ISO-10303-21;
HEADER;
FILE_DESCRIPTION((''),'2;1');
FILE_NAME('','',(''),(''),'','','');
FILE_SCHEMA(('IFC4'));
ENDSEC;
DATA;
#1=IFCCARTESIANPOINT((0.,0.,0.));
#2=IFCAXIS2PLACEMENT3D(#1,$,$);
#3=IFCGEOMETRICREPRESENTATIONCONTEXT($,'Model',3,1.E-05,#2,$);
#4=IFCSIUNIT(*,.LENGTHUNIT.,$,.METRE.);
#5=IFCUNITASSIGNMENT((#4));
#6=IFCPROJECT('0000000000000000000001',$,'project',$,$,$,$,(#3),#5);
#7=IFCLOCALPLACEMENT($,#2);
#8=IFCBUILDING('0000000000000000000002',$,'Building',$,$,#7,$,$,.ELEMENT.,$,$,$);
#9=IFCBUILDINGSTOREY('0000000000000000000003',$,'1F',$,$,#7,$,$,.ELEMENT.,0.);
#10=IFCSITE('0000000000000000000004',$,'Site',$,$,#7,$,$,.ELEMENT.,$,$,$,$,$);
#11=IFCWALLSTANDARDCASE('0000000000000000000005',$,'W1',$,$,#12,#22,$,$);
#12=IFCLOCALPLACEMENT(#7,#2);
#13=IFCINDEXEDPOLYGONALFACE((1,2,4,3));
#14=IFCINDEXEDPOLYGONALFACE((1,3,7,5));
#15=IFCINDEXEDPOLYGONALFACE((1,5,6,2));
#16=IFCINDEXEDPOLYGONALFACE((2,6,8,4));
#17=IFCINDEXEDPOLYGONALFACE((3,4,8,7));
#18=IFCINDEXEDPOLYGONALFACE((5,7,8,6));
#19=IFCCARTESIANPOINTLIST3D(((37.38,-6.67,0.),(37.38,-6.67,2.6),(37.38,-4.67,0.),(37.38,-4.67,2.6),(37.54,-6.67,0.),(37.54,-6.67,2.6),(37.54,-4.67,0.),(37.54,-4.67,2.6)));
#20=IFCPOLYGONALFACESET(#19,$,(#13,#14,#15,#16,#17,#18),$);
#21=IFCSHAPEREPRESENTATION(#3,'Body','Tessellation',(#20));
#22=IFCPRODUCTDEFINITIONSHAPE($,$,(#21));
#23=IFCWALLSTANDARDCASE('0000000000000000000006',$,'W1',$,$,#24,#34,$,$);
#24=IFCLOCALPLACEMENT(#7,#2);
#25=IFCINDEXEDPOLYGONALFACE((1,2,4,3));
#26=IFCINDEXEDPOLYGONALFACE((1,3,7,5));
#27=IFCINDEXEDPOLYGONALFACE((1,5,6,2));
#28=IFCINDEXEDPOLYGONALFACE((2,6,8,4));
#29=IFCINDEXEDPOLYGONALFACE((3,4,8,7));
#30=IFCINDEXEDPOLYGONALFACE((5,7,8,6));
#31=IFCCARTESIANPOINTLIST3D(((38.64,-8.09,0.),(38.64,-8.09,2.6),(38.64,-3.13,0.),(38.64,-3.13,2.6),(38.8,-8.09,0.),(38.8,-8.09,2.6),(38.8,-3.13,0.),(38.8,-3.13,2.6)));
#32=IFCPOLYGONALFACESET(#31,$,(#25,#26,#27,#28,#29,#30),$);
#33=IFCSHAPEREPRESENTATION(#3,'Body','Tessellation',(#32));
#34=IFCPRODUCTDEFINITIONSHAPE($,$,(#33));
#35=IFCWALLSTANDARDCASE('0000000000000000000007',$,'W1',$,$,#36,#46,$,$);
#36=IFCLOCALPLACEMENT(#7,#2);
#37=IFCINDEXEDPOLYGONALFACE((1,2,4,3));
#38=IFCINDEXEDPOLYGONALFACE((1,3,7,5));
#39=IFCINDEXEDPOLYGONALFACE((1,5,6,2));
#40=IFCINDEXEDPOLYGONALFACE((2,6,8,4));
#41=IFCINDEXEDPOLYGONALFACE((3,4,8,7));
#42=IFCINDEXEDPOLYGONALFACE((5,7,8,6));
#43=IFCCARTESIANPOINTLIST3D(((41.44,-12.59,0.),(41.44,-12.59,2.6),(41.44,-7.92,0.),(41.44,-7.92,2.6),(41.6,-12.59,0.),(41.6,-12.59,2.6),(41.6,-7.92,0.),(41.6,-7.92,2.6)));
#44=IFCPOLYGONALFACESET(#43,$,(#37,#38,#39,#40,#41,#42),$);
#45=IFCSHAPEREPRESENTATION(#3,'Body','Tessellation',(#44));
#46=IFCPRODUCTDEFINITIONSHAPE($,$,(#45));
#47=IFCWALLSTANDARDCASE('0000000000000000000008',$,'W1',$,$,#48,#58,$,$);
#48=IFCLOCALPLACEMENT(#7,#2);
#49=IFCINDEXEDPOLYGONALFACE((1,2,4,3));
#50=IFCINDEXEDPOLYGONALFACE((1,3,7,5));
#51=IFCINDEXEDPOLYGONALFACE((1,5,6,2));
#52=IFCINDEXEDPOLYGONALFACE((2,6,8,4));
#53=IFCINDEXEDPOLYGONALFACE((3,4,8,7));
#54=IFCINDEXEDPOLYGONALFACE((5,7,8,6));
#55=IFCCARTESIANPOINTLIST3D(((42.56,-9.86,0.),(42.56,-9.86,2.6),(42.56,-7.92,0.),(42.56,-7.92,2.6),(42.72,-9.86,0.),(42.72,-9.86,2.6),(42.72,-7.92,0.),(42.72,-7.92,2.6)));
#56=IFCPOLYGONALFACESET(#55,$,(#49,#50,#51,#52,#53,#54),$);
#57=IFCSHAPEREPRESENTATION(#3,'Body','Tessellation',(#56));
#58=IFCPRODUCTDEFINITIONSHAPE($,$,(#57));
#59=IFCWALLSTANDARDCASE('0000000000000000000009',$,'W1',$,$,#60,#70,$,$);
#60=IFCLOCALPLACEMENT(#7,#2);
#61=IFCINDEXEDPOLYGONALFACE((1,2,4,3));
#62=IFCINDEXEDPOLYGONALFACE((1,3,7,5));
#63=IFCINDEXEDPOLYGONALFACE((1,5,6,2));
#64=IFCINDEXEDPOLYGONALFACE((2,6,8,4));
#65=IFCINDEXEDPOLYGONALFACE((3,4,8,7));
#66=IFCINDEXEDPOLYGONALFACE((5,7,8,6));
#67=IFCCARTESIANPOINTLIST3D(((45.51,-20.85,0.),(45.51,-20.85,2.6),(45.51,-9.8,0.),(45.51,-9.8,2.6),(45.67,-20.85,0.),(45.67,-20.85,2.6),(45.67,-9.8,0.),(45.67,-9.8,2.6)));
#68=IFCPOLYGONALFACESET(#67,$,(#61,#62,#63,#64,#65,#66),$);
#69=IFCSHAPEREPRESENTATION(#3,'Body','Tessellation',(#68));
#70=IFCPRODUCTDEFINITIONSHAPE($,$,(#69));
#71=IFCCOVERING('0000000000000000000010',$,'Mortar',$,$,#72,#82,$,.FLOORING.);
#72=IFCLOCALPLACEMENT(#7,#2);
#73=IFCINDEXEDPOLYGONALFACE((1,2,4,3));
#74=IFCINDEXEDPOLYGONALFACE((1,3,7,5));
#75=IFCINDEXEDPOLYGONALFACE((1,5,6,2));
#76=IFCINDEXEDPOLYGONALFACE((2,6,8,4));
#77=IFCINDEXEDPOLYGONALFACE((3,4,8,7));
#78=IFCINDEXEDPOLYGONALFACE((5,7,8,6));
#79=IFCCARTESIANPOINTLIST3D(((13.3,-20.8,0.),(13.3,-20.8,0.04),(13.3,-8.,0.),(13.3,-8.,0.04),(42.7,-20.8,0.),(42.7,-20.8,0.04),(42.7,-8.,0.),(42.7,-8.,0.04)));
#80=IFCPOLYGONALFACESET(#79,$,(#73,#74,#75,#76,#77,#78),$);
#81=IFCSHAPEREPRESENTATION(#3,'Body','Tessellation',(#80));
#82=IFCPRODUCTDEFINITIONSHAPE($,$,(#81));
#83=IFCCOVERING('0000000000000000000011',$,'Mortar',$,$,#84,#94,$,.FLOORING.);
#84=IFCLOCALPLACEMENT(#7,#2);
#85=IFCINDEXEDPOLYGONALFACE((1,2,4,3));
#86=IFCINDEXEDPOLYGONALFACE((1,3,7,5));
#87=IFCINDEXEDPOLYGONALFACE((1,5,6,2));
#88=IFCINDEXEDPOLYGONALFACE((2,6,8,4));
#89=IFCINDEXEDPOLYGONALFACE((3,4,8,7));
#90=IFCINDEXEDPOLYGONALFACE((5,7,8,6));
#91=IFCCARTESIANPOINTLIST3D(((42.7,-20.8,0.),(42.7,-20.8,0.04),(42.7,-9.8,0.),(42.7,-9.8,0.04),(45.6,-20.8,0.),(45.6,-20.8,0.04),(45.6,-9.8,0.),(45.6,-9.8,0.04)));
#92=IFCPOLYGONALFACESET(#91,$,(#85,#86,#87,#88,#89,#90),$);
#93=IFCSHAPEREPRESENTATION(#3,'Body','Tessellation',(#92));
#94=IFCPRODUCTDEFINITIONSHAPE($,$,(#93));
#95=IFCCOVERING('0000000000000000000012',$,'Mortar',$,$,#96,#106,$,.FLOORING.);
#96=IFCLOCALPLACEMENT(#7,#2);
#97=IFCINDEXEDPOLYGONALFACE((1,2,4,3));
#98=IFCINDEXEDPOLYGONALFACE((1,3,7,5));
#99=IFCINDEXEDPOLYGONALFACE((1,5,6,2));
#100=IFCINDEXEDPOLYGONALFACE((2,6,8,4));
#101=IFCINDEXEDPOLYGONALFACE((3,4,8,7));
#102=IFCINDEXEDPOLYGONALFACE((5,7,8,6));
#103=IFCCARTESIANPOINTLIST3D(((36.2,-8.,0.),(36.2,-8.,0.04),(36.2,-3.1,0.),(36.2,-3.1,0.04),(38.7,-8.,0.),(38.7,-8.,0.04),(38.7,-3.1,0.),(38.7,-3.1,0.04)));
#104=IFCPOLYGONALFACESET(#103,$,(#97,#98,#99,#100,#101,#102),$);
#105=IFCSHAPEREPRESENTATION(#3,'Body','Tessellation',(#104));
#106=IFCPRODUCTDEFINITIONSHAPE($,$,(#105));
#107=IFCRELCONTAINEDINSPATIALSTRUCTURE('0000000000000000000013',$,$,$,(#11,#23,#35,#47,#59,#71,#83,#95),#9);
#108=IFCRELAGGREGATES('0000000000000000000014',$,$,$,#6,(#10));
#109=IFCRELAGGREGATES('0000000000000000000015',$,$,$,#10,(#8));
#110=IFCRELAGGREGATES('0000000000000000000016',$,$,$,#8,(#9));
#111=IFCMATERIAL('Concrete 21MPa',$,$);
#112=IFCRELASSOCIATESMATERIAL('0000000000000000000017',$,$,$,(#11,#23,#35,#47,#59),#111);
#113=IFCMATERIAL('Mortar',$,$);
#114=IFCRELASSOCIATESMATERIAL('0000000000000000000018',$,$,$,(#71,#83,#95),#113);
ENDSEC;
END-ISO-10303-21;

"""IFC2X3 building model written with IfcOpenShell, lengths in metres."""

from ifc_helpers import new_model, si_unit, frame, origin, origin_2d, place, context, project, spatial, rectangle, extrude, material, element, save


model = new_model("IFC2X3")

# Units and contexts
model_context = context("Model", 3, precision=1e-05, world=origin())
ifc_project = project(units=[si_unit("LENGTHUNIT", "METRE")], contexts=[model_context])

# Site, building, storey
placement = place(None, origin())
site = spatial("IfcSite", under=ifc_project, at=placement, Name="Site", CompositionType="ELEMENT")
building = spatial("IfcBuilding", under=site, at=placement, Name="Building", CompositionType="ELEMENT")
storey = spatial("IfcBuildingStorey", under=building, at=placement, Name="1F", CompositionType="ELEMENT", Elevation=0.0)

# Shared definitions
ifc_material_1 = material(Name="Concrete 21MPa")

# Walls
wall_1_placement = place(None, frame((37.46, -5.67, 0.0)))
element("IfcWallStandardCase", 1, at=wall_1_placement, inside=storey, material=ifc_material_1, Name="W1", context=model_context, shape_type="SweptSolid", body=[
    extrude(rectangle(XDim=0.16, YDim=2.0, at=origin_2d()), origin(), (0.0, 0.0, 1.0), 2.6),
])
wall_2_placement = place(None, frame((38.72, -5.61, 0.0)))
element("IfcWallStandardCase", 2, at=wall_2_placement, inside=storey, material=ifc_material_1, Name="W1", context=model_context, shape_type="SweptSolid", body=[
    extrude(rectangle(XDim=0.16, YDim=4.96, at=origin_2d()), origin(), (0.0, 0.0, 1.0), 2.6),
])
wall_3_placement = place(None, frame((41.52, -10.255, 0.0)))
element("IfcWallStandardCase", 3, at=wall_3_placement, inside=storey, material=ifc_material_1, Name="W1", context=model_context, shape_type="SweptSolid", body=[
    extrude(rectangle(XDim=0.16, YDim=4.67, at=origin_2d()), origin(), (0.0, 0.0, 1.0), 2.6),
])
wall_4_placement = place(None, frame((42.64, -8.89, 0.0)))
element("IfcWallStandardCase", 4, at=wall_4_placement, inside=storey, material=ifc_material_1, Name="W1", context=model_context, shape_type="SweptSolid", body=[
    extrude(rectangle(XDim=0.16, YDim=1.94, at=origin_2d()), origin(), (0.0, 0.0, 1.0), 2.6),
])
wall_5_placement = place(None, frame((45.59, -15.325, 0.0)))
element("IfcWallStandardCase", 5, at=wall_5_placement, inside=storey, material=ifc_material_1, Name="W1", context=model_context, shape_type="SweptSolid", body=[
    extrude(rectangle(XDim=0.16, YDim=11.05, at=origin_2d()), origin(), (0.0, 0.0, 1.0), 2.6),
])

# Coverings
ifc_material_2 = material(Name="Mortar")
covering_1_placement = place(None, frame((28.0, -14.4, 0.0)))
element("IfcCovering", 6, at=covering_1_placement, inside=storey, material=ifc_material_2, Name="Mortar", PredefinedType="FLOORING", context=model_context, shape_type="SweptSolid", body=[
    extrude(rectangle(XDim=29.4, YDim=12.8, at=origin_2d()), origin(), (0.0, 0.0, 1.0), 0.04),
])
covering_2_placement = place(None, frame((44.15, -15.3, 0.0)))
element("IfcCovering", 7, at=covering_2_placement, inside=storey, material=ifc_material_2, Name="Mortar", PredefinedType="FLOORING", context=model_context, shape_type="SweptSolid", body=[
    extrude(rectangle(XDim=2.9, YDim=11.0, at=origin_2d()), origin(), (0.0, 0.0, 1.0), 0.04),
])
covering_3_placement = place(None, frame((37.45, -5.55, 0.0)))
element("IfcCovering", 8, at=covering_3_placement, inside=storey, material=ifc_material_2, Name="Mortar", PredefinedType="FLOORING", context=model_context, shape_type="SweptSolid", body=[
    extrude(rectangle(XDim=2.5, YDim=4.9, at=origin_2d()), origin(), (0.0, 0.0, 1.0), 0.04),
])

save(model, "model.ifc")
